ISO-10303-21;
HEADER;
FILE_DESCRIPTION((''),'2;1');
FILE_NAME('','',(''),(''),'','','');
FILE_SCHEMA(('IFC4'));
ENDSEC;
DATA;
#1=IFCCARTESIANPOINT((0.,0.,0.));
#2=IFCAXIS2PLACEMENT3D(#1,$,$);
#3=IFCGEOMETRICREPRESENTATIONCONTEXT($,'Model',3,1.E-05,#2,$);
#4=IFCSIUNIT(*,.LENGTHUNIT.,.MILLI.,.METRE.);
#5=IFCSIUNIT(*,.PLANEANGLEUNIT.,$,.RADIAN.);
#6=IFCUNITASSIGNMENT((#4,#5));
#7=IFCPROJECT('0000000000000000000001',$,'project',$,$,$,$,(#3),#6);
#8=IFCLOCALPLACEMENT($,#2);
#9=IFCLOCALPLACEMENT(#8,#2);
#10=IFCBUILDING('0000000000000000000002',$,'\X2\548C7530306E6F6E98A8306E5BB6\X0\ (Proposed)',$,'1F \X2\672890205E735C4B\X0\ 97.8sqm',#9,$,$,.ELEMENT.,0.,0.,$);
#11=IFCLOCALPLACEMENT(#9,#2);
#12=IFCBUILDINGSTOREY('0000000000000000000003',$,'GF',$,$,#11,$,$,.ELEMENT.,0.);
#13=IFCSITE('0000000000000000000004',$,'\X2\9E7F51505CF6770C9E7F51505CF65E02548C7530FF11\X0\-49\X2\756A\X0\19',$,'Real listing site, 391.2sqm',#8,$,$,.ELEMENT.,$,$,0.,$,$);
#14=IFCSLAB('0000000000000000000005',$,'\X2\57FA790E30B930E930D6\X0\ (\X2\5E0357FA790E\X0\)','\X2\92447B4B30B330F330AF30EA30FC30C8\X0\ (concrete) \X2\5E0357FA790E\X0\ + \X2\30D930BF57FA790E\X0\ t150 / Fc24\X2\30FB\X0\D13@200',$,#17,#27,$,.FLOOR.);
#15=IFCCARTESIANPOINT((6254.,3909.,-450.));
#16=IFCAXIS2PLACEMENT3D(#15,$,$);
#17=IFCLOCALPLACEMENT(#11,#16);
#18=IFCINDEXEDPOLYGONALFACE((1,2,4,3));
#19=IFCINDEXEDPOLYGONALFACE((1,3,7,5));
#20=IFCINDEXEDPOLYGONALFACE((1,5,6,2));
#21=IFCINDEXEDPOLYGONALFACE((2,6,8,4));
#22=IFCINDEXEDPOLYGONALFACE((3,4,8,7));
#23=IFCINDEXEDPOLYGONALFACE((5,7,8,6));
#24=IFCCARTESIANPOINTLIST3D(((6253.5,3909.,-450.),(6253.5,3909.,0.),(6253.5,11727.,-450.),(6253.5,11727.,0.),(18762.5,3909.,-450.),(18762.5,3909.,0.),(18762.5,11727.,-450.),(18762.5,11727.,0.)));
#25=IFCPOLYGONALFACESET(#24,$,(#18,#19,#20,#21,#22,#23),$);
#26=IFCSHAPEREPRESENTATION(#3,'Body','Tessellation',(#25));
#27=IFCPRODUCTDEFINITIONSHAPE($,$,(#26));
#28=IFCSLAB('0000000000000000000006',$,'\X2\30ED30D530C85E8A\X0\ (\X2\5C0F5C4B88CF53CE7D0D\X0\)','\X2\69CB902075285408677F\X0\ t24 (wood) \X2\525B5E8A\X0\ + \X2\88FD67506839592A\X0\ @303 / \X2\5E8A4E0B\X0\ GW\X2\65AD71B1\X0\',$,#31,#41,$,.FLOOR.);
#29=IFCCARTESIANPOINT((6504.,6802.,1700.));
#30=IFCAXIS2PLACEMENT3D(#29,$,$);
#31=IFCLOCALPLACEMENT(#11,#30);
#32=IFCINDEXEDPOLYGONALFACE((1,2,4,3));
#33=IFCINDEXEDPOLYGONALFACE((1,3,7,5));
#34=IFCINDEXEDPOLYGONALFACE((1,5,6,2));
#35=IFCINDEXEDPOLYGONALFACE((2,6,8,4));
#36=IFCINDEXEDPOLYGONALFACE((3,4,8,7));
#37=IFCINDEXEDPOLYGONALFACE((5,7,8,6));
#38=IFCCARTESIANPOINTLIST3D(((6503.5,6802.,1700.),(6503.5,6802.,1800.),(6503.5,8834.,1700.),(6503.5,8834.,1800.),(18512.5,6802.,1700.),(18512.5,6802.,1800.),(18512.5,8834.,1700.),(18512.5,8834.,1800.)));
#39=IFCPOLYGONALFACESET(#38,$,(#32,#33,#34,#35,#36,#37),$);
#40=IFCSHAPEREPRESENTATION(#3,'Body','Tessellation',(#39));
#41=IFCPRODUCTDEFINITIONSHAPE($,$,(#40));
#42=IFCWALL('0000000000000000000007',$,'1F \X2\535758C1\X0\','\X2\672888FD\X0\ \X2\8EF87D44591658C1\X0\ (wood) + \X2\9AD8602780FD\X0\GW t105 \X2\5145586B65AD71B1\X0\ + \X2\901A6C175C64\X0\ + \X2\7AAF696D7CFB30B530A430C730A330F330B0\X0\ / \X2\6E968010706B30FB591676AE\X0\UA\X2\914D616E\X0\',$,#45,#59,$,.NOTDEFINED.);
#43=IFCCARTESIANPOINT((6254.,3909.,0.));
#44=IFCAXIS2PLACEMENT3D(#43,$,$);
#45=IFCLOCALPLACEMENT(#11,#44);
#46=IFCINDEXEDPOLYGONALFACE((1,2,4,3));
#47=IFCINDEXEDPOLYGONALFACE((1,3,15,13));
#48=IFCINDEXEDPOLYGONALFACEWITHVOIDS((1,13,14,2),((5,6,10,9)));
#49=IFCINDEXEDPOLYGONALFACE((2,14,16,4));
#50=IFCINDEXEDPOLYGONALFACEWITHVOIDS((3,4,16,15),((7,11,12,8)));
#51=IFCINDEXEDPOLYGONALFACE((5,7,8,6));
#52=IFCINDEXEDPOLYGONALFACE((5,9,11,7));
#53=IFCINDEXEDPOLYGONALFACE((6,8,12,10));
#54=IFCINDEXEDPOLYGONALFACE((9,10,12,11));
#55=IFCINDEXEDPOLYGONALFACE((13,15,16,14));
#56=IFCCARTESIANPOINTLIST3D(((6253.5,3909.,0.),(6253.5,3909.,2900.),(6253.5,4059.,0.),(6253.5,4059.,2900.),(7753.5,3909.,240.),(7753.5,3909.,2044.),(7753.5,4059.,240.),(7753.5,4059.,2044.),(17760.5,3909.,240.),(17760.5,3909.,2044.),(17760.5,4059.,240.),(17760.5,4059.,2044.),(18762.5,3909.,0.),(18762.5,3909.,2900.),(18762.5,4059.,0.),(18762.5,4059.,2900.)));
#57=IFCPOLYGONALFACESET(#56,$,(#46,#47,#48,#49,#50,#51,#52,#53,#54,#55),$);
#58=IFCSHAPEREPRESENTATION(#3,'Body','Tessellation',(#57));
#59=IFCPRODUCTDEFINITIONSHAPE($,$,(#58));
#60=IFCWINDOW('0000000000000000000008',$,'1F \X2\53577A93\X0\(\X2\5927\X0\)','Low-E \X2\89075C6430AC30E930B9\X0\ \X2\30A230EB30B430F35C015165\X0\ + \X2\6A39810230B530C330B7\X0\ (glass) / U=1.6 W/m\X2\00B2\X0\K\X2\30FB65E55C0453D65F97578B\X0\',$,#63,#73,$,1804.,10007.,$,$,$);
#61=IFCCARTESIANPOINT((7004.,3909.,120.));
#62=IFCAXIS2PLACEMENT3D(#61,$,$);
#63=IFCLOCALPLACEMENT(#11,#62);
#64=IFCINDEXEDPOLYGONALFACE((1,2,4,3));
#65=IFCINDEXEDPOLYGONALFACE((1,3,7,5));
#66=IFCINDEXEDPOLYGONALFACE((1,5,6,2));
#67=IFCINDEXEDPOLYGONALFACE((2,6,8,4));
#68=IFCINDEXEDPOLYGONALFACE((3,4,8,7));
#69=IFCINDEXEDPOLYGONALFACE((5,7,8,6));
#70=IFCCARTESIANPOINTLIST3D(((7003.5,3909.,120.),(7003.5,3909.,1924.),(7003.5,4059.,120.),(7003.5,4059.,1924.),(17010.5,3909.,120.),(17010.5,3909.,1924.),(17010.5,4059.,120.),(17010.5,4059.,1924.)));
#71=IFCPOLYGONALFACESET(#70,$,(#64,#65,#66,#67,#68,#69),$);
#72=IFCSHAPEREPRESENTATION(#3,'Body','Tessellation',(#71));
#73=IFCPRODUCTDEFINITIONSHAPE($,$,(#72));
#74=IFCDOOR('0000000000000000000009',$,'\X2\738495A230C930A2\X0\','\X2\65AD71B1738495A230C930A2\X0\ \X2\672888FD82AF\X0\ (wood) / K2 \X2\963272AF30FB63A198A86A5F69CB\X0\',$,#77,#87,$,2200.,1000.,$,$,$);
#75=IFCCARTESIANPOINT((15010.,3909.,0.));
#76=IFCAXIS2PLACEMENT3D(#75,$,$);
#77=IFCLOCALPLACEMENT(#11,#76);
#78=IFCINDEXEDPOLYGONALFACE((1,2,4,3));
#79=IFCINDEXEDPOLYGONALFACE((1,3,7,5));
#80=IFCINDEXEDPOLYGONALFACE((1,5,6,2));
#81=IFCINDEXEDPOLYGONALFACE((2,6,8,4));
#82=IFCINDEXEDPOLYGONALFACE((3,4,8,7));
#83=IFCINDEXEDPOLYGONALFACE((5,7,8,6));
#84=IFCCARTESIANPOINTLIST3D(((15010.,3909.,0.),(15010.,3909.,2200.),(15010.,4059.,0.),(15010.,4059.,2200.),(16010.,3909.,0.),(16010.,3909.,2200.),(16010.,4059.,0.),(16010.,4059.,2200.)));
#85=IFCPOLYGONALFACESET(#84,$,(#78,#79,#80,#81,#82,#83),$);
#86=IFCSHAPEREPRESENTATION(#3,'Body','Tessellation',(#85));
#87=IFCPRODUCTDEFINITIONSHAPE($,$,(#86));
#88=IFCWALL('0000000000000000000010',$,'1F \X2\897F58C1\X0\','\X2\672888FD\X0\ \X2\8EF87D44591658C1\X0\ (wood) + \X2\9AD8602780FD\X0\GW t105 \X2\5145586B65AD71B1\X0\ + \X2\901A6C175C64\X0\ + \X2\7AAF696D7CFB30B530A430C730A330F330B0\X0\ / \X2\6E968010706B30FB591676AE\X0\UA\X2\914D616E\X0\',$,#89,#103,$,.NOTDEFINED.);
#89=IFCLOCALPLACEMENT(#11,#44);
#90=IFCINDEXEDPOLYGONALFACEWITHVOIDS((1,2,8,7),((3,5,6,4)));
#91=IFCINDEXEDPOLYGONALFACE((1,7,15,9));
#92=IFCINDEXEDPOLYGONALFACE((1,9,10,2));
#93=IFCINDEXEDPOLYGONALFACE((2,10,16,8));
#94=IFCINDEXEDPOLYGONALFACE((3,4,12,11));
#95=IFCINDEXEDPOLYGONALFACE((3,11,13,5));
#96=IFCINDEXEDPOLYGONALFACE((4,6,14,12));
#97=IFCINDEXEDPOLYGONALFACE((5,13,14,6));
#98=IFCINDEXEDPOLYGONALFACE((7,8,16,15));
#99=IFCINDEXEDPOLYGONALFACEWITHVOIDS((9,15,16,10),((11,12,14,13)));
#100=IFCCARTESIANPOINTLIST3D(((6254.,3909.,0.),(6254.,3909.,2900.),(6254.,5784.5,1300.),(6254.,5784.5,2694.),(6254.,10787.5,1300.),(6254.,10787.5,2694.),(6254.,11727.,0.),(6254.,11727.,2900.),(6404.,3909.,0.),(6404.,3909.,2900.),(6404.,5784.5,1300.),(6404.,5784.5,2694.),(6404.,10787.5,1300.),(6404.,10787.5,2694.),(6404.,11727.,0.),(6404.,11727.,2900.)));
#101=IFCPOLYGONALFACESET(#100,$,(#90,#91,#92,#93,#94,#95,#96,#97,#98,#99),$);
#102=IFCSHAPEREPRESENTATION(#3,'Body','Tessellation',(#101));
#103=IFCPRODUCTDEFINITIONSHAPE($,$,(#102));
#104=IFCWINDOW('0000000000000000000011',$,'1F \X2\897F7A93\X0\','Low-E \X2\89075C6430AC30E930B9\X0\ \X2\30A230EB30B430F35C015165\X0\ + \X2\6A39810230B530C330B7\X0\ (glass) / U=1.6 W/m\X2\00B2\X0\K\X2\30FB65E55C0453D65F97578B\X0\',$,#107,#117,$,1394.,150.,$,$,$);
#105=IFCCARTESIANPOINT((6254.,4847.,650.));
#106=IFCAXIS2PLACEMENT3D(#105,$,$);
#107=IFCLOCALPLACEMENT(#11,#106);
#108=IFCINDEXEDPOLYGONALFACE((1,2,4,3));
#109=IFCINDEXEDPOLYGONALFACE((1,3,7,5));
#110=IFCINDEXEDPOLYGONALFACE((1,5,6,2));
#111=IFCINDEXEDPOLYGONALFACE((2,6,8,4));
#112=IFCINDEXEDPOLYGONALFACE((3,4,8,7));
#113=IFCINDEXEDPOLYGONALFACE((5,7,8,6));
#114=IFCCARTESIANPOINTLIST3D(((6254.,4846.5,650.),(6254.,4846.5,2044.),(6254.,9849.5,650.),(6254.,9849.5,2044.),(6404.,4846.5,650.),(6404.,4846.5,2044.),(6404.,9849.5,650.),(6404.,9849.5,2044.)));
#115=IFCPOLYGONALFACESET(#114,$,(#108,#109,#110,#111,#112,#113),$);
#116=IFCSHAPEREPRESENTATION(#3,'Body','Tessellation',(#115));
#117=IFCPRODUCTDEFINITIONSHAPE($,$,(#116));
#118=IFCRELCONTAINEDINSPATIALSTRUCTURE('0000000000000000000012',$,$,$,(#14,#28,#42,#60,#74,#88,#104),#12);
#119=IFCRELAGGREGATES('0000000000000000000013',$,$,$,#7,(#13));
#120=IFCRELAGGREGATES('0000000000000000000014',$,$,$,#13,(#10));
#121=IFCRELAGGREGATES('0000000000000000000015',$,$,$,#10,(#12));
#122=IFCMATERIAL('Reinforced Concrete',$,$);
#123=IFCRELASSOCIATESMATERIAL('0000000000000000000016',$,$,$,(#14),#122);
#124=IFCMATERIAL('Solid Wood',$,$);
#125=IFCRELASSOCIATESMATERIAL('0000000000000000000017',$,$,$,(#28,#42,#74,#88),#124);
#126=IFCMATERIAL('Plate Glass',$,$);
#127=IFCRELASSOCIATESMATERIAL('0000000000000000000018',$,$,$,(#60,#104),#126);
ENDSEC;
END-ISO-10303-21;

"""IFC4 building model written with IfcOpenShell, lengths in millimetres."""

from ifc_helpers import new_model, si_unit, frame, frame_2d, origin, place, context, project, spatial, rectangle, extrude, material, element, fill, save


model = new_model("IFC4")

# Units and contexts
model_context = context("Model", 3, precision=1e-05, world=origin())
ifc_project = project(units=[si_unit("LENGTHUNIT", "METRE", prefix="MILLI"), si_unit("PLANEANGLEUNIT", "RADIAN")], contexts=[model_context])

# Site, building, storey
site_placement = place(None, origin())
site = spatial("IfcSite", under=ifc_project, at=site_placement, Name="鹿児島県鹿児島市和田１-49番19", ObjectType="Real listing site, 391.2sqm", CompositionType="ELEMENT", RefElevation=0.0)
building_placement = place(site_placement, origin())
building = spatial("IfcBuilding", under=site, at=building_placement, Name="和田の潮風の家 (Proposed)", ObjectType="1F 木造平屋 97.8sqm", CompositionType="ELEMENT", ElevationOfRefHeight=0.0, ElevationOfTerrain=0.0)
storey_placement = place(building_placement, origin())
storey = spatial("IfcBuildingStorey", under=building, at=storey_placement, Name="GF", CompositionType="ELEMENT", Elevation=0.0)

# Slabs
ifc_material_1 = material(Name="Reinforced Concrete")
slab_1_placement = place(storey_placement, frame((6254.0, 3909.0, -450.0)))
element("IfcSlab", 1, at=slab_1_placement, inside=storey, material=ifc_material_1, Name="基礎スラブ (布基礎)", Description="鉄筋コンクリート (concrete) 布基礎 + ベタ基礎 t150 / Fc24・D13@200", PredefinedType="FLOOR", context=model_context, shape_type="SweptSolid", body=[
    extrude(rectangle(XDim=12509.0, YDim=7818.0, at=frame_2d((6254.0, 3909.0))), frame((6254.0, 3909.0, -450.0)), (0.0, 0.0, 1.0), 450.0),
])
ifc_material_2 = material(Name="Solid Wood")
slab_2_placement = place(storey_placement, frame((6504.0, 6802.0, 1700.0)))
element("IfcSlab", 2, at=slab_2_placement, inside=storey, material=ifc_material_2, Name="ロフト床 (小屋裏収納)", Description="構造用合板 t24 (wood) 剛床 + 製材根太 @303 / 床下 GW断熱", PredefinedType="FLOOR", context=model_context, shape_type="SweptSolid", body=[
    extrude(rectangle(XDim=12009.0, YDim=2032.0, at=frame_2d((6004.0, 1016.0))), frame((6504.0, 6802.0, 1700.0)), (0.0, 0.0, 1.0), 100.0),
])

# Wall, openings, window, door
wall_1_placement = place(storey_placement, frame((6254.0, 3909.0, 0.0)))
wall_1 = element("IfcWall", 3, at=wall_1_placement, inside=storey, material=ifc_material_2, Name="1F 南壁", Description="木製 軸組外壁 (wood) + 高性能GW t105 充填断熱 + 通気層 + 窯業系サイディング / 準耐火・外皮UA配慮", PredefinedType="NOTDEFINED", context=model_context, shape_type="SweptSolid", body=[
    extrude(rectangle(XDim=12509.0, YDim=150.0, at=frame_2d((6254.0, 75.0))), frame((6254.0, 3909.0, 0.0)), (0.0, 0.0, 1.0), 2900.0),
])
opening_1_placement = place(storey_placement, frame((7004.0, 3909.0, 120.0)))
opening_1 = element("IfcOpeningElement", 4, at=opening_1_placement, cuts=wall_1, PredefinedType="NOTDEFINED", context=model_context, shape_type="SweptSolid", body=[
    extrude(rectangle(XDim=10007.0, YDim=150.0, at=frame_2d((5003.0, 75.0))), frame((7004.0, 3909.0, 120.0)), (0.0, 0.0, 1.0), 1804.0),
])
opening_2_placement = place(storey_placement, frame((15010.0, 3909.0, 0.0)))
opening_2 = element("IfcOpeningElement", 5, at=opening_2_placement, cuts=wall_1, PredefinedType="NOTDEFINED", context=model_context, shape_type="SweptSolid", body=[
    extrude(rectangle(XDim=1000.0, YDim=150.0, at=frame_2d((500.0, 75.0))), frame((15010.0, 3909.0, 0.0)), (0.0, 0.0, 1.0), 2200.0),
])
ifc_material_3 = material(Name="Plate Glass")
window_1_placement = place(storey_placement, frame((7004.0, 3909.0, 120.0)))
window_1 = element("IfcWindow", 6, at=window_1_placement, inside=storey, material=ifc_material_3, Name="1F 南窓(大)", Description="Low-E 複層ガラス アルゴン封入 + 樹脂サッシ (glass) / U=1.6 W/m²K・日射取得型", OverallHeight=1804.0, OverallWidth=10007.0, context=model_context, shape_type="SweptSolid", body=[
    extrude(rectangle(XDim=10007.0, YDim=150.0, at=frame_2d((5003.0, 75.0))), frame((7004.0, 3909.0, 120.0)), (0.0, 0.0, 1.0), 1804.0),
])
fill(opening_1, window_1)
door_1_placement = place(storey_placement, frame((15010.0, 3909.0, 0.0)))
door_1 = element("IfcDoor", 7, at=door_1_placement, inside=storey, material=ifc_material_2, Name="玄関ドア", Description="断熱玄関ドア 木製芯 (wood) / K2 防犯・採風機構", OverallHeight=2200.0, OverallWidth=1000.0, context=model_context, shape_type="SweptSolid", body=[
    extrude(rectangle(XDim=1000.0, YDim=150.0, at=frame_2d((500.0, 75.0))), frame((15010.0, 3909.0, 0.0)), (0.0, 0.0, 1.0), 2200.0),
])
fill(opening_2, door_1)

# Wall, opening, window
wall_2_placement = place(storey_placement, frame((6254.0, 3909.0, 0.0)))
wall_2 = element("IfcWall", 8, at=wall_2_placement, inside=storey, material=ifc_material_2, Name="1F 西壁", Description="木製 軸組外壁 (wood) + 高性能GW t105 充填断熱 + 通気層 + 窯業系サイディング / 準耐火・外皮UA配慮", PredefinedType="NOTDEFINED", context=model_context, shape_type="SweptSolid", body=[
    extrude(rectangle(XDim=150.0, YDim=7818.0, at=frame_2d((75.0, 3909.0))), frame((6254.0, 3909.0, 0.0)), (0.0, 0.0, 1.0), 2900.0),
])
opening_3_placement = place(storey_placement, frame((6254.0, 4847.0, 650.0)))
opening_3 = element("IfcOpeningElement", 9, at=opening_3_placement, cuts=wall_2, PredefinedType="NOTDEFINED", context=model_context, shape_type="SweptSolid", body=[
    extrude(rectangle(XDim=150.0, YDim=5003.0, at=frame_2d((75.0, 2501.0))), frame((6254.0, 4847.0, 650.0)), (0.0, 0.0, 1.0), 1394.0),
])
window_2_placement = place(storey_placement, frame((6254.0, 4847.0, 650.0)))
window_2 = element("IfcWindow", 10, at=window_2_placement, inside=storey, material=ifc_material_3, Name="1F 西窓", Description="Low-E 複層ガラス アルゴン封入 + 樹脂サッシ (glass) / U=1.6 W/m²K・日射取得型", OverallHeight=1394.0, OverallWidth=150.0, context=model_context, shape_type="SweptSolid", body=[
    extrude(rectangle(XDim=150.0, YDim=5003.0, at=frame_2d((75.0, 2501.0))), frame((6254.0, 4847.0, 650.0)), (0.0, 0.0, 1.0), 1394.0),
])
fill(opening_3, window_2)

save(model, "model.ifc")
